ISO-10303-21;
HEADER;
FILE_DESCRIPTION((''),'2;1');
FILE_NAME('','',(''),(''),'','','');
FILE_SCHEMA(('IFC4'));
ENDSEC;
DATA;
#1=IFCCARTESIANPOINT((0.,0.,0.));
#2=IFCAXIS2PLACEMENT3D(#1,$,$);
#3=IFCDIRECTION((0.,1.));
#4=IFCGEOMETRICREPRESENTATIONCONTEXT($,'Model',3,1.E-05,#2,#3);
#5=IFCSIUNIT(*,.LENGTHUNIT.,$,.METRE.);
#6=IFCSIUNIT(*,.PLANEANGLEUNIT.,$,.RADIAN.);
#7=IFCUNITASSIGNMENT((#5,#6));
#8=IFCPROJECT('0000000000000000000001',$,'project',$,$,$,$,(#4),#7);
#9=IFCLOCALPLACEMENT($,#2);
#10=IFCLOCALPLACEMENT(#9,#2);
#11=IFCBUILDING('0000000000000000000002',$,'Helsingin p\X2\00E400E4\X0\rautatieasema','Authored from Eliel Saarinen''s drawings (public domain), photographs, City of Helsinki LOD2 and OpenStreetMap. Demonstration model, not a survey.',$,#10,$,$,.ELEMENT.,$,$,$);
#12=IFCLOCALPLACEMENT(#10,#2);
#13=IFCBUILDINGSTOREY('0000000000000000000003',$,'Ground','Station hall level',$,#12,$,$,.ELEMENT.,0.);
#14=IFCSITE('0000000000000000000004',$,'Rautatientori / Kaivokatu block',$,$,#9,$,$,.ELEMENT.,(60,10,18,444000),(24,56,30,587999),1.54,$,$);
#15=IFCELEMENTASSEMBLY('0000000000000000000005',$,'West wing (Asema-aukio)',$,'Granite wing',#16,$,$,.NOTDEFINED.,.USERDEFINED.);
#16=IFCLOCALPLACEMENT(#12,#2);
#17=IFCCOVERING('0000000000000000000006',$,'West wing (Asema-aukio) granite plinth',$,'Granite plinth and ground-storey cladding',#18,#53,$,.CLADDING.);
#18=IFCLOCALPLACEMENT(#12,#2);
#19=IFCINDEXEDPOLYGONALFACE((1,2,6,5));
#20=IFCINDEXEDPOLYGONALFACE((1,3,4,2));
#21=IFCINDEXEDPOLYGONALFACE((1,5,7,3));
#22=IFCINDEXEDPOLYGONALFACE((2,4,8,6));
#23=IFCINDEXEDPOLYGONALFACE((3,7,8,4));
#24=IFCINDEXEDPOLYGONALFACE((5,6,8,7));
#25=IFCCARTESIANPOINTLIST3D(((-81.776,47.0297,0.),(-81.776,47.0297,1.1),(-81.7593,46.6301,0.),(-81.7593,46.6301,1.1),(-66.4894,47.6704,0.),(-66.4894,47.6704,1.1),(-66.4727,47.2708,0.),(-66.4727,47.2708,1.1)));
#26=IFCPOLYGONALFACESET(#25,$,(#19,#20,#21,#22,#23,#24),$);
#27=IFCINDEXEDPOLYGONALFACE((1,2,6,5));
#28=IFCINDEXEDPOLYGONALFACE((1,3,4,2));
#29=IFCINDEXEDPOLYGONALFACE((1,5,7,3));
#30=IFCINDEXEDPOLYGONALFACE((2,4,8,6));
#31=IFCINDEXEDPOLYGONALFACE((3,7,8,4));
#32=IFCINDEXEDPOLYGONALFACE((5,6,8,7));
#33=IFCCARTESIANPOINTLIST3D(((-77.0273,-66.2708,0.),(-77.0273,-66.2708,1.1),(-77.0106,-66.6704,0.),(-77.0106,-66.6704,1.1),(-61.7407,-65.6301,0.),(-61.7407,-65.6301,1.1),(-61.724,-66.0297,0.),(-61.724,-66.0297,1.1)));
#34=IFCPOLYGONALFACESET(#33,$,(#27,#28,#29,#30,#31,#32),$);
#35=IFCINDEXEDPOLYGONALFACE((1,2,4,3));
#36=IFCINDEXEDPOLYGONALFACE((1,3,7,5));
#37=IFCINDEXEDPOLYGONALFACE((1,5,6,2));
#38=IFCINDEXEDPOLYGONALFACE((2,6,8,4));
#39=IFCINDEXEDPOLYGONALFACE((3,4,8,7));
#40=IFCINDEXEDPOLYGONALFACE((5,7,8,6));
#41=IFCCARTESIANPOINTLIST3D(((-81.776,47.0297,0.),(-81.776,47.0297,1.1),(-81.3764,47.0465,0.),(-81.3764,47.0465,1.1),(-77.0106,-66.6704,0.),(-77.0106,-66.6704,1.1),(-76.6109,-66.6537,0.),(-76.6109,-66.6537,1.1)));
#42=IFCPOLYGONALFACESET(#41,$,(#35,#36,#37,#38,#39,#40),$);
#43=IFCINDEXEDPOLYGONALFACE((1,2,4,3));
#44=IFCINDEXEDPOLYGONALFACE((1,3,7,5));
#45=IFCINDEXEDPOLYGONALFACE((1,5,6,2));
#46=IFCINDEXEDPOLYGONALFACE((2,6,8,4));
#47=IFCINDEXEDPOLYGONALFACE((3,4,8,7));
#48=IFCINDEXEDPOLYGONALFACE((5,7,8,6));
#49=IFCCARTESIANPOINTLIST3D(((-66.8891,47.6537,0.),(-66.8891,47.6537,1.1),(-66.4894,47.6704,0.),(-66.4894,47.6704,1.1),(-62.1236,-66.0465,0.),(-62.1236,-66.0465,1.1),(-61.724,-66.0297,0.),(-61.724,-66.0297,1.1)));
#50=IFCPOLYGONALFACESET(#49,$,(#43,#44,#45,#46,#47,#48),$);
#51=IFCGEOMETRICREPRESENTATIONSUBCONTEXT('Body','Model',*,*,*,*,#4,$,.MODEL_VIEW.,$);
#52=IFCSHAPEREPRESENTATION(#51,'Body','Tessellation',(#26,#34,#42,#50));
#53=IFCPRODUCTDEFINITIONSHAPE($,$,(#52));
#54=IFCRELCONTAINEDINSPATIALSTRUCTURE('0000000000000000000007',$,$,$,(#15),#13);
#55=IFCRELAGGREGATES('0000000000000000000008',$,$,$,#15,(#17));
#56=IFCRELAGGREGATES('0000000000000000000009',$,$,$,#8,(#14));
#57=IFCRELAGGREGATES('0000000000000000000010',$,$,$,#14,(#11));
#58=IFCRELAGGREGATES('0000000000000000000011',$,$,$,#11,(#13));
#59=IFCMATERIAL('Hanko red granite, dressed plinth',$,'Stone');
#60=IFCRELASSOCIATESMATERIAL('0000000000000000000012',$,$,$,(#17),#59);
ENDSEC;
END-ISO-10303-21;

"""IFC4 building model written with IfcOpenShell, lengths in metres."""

from ifc_helpers import new_model, si_unit, direction, frame, frame_2d, origin, place, context, subcontext, project, spatial, rectangle, extrude, material, element, aggregate, save


model = new_model("IFC4")

# Units and contexts
model_context = context("Model", 3, precision=1e-05, world=origin(), true_north=direction((0.0, 1.0)))
body_context = subcontext(model_context, "Body", "Model", "MODEL_VIEW")
ifc_project = project(units=[si_unit("LENGTHUNIT", "METRE"), si_unit("PLANEANGLEUNIT", "RADIAN")], contexts=[model_context])

# Site, building, storey
site_placement = place(None, origin())
site = spatial("IfcSite", under=ifc_project, at=site_placement, Name="Rautatientori / Kaivokatu block", CompositionType="ELEMENT", RefLatitude=(60, 10, 18, 444000), RefLongitude=(24, 56, 30, 587999), RefElevation=1.54)
building_placement = place(site_placement, origin())
building = spatial("IfcBuilding", under=site, at=building_placement, Name="Helsingin päärautatieasema", Description="Authored from Eliel Saarinen's drawings (public domain), photographs, City of Helsinki LOD2 and OpenStreetMap. Demonstration model, not a survey.", CompositionType="ELEMENT")
storey_placement = place(building_placement, origin())
storey = spatial("IfcBuildingStorey", under=building, at=storey_placement, Name="Ground", Description="Station hall level", CompositionType="ELEMENT", Elevation=0.0)

# Element assembly, covering
assembly_placement = place(building_placement, origin())
assembly = element("IfcElementAssembly", 1, at=assembly_placement, inside=storey, Name="West wing (Asema-aukio)", ObjectType="Granite wing", AssemblyPlace="NOTDEFINED", PredefinedType="USERDEFINED")
ifc_material_1 = material(Name="Hanko red granite, dressed plinth", Category="Stone")
covering_placement = place(building_placement, origin())
covering = element("IfcCovering", 2, at=covering_placement, material=ifc_material_1, Name="West wing (Asema-aukio) granite plinth", ObjectType="Granite plinth and ground-storey cladding", PredefinedType="CLADDING", context=body_context, shape_type="SweptSolid", body=[
    extrude(rectangle(XDim=15.3, YDim=0.4, at=frame_2d((0.0, 0.0), x_axis=(-0.999123, -0.041876))), frame((-74.1243, 47.1503, 0.0)), (0.0, 0.0, 1.0), 1.1),
    extrude(rectangle(XDim=15.3, YDim=0.4, at=frame_2d((0.0, 0.0), x_axis=(0.999123, 0.041876))), frame((-69.3757, -66.1503, 0.0)), (0.0, 0.0, 1.0), 1.1),
    extrude(rectangle(XDim=113.8, YDim=0.4, at=frame_2d((0.0, 0.0), x_axis=(0.041876, -0.999123))), frame((-79.1935, -9.812, 0.0)), (0.0, 0.0, 1.0), 1.1),
    extrude(rectangle(XDim=113.8, YDim=0.4, at=frame_2d((0.0, 0.0), x_axis=(-0.041876, 0.999123))), frame((-64.3065, -9.188, 0.0)), (0.0, 0.0, 1.0), 1.1),
])
aggregate(assembly, [covering])

save(model, "model.ifc")
